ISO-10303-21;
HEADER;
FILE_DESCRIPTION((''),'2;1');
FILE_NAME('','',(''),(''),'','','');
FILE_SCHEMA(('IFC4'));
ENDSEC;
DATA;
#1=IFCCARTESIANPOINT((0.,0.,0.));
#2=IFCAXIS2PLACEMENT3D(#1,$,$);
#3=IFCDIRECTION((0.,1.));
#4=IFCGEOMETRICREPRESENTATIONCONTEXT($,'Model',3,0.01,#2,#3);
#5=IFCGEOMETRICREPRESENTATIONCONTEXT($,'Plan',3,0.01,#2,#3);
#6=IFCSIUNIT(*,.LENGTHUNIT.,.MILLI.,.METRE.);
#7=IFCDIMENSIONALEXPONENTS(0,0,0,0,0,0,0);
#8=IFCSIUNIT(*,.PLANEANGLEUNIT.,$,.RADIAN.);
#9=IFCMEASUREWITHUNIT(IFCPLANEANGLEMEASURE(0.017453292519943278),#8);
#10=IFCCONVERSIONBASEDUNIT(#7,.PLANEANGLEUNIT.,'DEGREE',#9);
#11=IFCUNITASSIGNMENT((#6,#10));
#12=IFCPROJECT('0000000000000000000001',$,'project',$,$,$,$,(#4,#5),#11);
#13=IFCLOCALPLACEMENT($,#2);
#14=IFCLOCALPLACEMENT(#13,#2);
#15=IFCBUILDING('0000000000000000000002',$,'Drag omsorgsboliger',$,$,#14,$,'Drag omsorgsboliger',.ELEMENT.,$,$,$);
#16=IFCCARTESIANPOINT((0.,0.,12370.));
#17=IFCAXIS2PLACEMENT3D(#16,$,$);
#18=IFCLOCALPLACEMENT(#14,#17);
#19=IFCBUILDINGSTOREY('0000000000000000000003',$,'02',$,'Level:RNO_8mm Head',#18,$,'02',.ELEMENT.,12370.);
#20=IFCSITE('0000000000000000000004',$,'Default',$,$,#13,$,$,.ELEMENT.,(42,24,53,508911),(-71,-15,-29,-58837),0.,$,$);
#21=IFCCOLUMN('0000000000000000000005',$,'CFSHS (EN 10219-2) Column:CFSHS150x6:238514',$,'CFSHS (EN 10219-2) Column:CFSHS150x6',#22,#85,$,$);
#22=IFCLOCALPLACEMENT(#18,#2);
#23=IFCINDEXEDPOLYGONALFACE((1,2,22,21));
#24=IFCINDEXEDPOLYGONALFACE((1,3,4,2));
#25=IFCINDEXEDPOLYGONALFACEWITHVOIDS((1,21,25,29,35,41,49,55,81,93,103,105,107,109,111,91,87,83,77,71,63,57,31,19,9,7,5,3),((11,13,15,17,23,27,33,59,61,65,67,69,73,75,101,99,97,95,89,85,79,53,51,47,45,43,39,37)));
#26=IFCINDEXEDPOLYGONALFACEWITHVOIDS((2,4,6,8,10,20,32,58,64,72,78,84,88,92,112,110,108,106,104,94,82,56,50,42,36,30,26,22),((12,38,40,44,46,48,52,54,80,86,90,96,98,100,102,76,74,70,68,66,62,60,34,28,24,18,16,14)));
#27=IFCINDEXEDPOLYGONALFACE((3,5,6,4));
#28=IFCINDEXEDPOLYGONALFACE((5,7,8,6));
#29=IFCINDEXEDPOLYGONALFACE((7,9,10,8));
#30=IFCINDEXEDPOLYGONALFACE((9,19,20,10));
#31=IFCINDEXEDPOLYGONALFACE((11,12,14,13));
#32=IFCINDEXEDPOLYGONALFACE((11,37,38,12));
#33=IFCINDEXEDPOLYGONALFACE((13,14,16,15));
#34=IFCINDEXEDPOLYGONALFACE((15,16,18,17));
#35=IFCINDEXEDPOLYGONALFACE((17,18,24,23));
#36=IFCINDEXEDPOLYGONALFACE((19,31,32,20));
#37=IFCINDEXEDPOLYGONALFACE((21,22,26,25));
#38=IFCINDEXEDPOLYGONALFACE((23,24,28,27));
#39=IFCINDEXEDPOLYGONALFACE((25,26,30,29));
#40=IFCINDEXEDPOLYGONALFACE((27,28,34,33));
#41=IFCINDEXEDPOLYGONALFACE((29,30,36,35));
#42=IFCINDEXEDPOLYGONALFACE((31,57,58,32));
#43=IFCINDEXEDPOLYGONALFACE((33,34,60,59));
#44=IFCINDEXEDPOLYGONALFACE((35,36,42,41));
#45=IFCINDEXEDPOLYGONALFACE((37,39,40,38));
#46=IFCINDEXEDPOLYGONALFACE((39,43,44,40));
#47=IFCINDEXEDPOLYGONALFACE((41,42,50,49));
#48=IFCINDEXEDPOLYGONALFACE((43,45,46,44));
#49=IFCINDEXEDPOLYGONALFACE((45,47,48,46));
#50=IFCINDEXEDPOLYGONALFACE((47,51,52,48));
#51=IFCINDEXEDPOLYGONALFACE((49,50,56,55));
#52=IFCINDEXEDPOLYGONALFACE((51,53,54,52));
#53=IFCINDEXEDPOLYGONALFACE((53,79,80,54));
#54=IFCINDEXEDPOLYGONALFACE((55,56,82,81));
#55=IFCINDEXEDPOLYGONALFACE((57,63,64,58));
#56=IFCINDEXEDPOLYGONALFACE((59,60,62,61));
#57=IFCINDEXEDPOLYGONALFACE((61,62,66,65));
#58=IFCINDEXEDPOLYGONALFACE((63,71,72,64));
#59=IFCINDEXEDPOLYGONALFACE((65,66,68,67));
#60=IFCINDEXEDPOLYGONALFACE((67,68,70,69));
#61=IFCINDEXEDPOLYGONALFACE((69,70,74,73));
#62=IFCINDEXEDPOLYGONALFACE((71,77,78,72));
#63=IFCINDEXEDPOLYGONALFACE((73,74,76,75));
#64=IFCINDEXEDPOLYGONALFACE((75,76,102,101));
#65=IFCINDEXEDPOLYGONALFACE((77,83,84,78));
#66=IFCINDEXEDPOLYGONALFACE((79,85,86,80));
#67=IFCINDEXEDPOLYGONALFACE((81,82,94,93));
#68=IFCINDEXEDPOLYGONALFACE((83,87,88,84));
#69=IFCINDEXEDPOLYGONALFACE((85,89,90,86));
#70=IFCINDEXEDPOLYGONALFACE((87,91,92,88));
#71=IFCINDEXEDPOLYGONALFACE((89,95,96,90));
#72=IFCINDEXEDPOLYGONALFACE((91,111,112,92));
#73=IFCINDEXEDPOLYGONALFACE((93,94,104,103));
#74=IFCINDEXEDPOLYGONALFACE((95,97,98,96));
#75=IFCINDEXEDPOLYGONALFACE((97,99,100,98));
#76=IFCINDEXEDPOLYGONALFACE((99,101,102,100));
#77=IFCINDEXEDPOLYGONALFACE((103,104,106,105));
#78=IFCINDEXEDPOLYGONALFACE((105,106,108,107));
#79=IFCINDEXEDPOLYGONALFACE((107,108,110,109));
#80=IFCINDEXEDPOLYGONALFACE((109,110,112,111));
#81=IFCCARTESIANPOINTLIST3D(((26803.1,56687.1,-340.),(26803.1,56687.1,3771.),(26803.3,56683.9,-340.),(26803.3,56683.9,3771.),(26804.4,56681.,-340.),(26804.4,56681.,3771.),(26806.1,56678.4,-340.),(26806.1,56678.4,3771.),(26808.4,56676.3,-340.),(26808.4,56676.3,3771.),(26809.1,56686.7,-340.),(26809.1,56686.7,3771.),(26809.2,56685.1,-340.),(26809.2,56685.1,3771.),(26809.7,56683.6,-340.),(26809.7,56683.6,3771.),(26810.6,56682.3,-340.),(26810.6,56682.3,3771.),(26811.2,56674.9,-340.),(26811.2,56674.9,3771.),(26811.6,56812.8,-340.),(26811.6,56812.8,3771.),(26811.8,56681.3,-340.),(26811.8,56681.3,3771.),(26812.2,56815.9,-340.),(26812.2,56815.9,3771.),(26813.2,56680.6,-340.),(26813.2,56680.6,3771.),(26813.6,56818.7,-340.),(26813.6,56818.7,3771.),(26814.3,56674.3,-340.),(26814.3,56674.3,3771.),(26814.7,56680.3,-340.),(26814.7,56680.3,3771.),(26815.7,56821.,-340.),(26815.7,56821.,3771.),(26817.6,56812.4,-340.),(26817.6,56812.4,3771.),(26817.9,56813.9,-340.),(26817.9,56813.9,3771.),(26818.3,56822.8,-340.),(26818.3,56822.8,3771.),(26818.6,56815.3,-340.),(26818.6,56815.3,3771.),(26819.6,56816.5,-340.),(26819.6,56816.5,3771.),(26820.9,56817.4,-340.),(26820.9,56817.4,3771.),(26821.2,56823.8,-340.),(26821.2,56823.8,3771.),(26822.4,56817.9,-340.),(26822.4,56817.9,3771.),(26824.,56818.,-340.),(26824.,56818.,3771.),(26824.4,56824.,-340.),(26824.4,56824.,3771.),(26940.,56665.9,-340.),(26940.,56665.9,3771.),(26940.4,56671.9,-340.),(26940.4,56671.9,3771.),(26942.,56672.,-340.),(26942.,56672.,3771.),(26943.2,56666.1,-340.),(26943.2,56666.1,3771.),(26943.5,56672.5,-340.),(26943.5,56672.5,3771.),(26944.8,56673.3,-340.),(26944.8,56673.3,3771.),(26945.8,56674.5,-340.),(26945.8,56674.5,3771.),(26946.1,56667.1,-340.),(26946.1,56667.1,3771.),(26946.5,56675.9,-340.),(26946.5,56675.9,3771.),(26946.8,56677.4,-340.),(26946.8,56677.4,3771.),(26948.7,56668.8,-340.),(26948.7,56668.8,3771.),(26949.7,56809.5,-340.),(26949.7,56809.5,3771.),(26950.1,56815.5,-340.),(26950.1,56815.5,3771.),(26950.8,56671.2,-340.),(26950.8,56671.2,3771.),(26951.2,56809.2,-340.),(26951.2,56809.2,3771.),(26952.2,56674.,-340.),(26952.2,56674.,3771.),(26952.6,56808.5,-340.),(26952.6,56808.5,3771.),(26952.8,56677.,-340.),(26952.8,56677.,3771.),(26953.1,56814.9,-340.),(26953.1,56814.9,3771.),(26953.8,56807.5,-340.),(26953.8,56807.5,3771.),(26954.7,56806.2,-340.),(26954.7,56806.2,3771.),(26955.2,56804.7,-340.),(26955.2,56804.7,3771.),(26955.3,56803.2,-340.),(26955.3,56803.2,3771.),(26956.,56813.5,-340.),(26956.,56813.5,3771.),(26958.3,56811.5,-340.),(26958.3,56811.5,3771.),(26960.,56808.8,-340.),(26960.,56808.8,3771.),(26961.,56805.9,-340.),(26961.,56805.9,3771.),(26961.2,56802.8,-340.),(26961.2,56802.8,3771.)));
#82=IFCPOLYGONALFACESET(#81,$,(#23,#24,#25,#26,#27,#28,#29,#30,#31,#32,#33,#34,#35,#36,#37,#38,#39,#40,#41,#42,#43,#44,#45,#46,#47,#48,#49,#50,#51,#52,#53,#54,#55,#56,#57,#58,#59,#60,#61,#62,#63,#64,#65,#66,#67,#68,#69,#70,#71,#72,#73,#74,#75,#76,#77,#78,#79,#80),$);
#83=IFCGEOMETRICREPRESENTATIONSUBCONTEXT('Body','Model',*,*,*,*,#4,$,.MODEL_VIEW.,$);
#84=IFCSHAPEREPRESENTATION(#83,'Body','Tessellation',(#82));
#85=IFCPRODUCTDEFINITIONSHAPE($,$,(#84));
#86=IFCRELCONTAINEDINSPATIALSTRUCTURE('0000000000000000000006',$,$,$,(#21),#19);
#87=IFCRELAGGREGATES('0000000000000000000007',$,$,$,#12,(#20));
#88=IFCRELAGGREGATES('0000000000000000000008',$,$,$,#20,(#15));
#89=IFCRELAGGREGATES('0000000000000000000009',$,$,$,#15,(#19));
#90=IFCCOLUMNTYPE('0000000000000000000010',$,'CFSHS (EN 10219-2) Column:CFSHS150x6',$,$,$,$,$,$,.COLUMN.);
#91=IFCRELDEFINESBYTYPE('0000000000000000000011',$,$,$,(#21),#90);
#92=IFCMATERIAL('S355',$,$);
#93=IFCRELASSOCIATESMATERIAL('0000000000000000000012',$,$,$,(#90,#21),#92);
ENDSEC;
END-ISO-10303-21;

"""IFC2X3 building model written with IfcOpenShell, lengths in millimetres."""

from ifc_helpers import new_model, entity, si_unit, converted_unit, direction, frame, frame_2d, origin, place, context, subcontext, project, spatial, polyline, circle_curve, parameter, trimmed, segment, composite_curve, outline, extrude, source, transform, mapped, material, type_object, type_shapes, element, save


model = new_model("IFC2X3")

# Units and contexts
model_context = context("Model", 3, precision=0.01, world=origin(), true_north=direction((0.0, 1.0)))
plan_context = context("Plan", 3, precision=0.01, world=origin(), true_north=direction((0.0, 1.0)))
body_context = subcontext(model_context, "Body", "Model", "MODEL_VIEW")
ifc_project = project(units=[si_unit("LENGTHUNIT", "METRE", prefix="MILLI"), converted_unit("PLANEANGLEUNIT", "DEGREE", entity("IfcPlaneAngleMeasure", 0.017453292519943278), si_unit("PLANEANGLEUNIT", "RADIAN"), dimensions=[0, 0, 0, 0, 0, 0, 0])], contexts=[model_context, plan_context])

# Site, building, storey
site_placement = place(None, origin())
site = spatial("IfcSite", under=ifc_project, at=site_placement, Name="Default", CompositionType="ELEMENT", RefLatitude=(42, 24, 53, 508911), RefLongitude=(-71, -15, -29, -58837), RefElevation=0.0)
building_placement = place(site_placement, origin())
building = spatial("IfcBuilding", under=site, at=building_placement, Name="Drag omsorgsboliger", LongName="Drag omsorgsboliger", CompositionType="ELEMENT")
storey_placement = place(building_placement, frame((0.0, 0.0, 12370.0)))
storey = spatial("IfcBuildingStorey", under=building, at=storey_placement, Name="02", ObjectType="Level:RNO_8mm Head", LongName="02", CompositionType="ELEMENT", Elevation=12370.0)

# Column
ifc_material = material(Name="S355")
column_type_1 = type_object("IfcColumnType", Name="CFSHS (EN 10219-2) Column:CFSHS150x6", PredefinedType="COLUMN", material=ifc_material)
shared_shape_1 = source(origin(), body_context, "Body", "SweptSolid", [
    extrude(outline(composite_curve([segment(polyline([(-63.0, -75.0), (63.0, -75.0)]), True, "CONTINUOUS"), segment(trimmed(circle_curve(frame_2d((63.0, -63.0), x_axis=(-1.0, 0.0)), 12.0), [parameter(90.0)], [parameter(180.0)], True, "PARAMETER"), True, "CONTINUOUS"), segment(polyline([(75.0, -63.0), (75.0, 63.0)]), True, "CONTINUOUS"), segment(trimmed(circle_curve(frame_2d((63.0, 63.0), x_axis=(-1.0, 0.0)), 12.0), [parameter(180.0)], [parameter(270.0)], True, "PARAMETER"), True, "CONTINUOUS"), segment(polyline([(63.0, 75.0), (-63.0, 75.0)]), True, "CONTINUOUS"), segment(trimmed(circle_curve(frame_2d((-63.0, 63.0), x_axis=(-1.0, 0.0)), 12.0), [parameter(270.0)], [parameter(360.0)], True, "PARAMETER"), True, "CONTINUOUS"), segment(polyline([(-75.0, 63.0), (-75.0, -63.0)]), True, "CONTINUOUS"), segment(trimmed(circle_curve(frame_2d((-63.0, -63.0), x_axis=(-1.0, 0.0)), 12.0), [parameter(360.0)], [parameter(90.0)], True, "PARAMETER"), True, "CONTINUOUS")], self_intersect=False), holes=[composite_curve([segment(trimmed(circle_curve(frame_2d((-63.0, -63.0), x_axis=(-1.0, 0.0)), 6.0), [parameter(360.0)], [parameter(90.0)], True, "PARAMETER"), False, "CONTINUOUS"), segment(polyline([(-69.0, -63.0), (-69.0, 63.0)]), True, "CONTINUOUS"), segment(trimmed(circle_curve(frame_2d((-63.0, 63.0), x_axis=(-1.0, 0.0)), 6.0), [parameter(270.0)], [parameter(360.0)], True, "PARAMETER"), False, "CONTINUOUS"), segment(polyline([(-63.0, 69.0), (63.0, 69.0)]), True, "CONTINUOUS"), segment(trimmed(circle_curve(frame_2d((63.0, 63.0), x_axis=(-1.0, 0.0)), 6.0), [parameter(180.0)], [parameter(270.0)], True, "PARAMETER"), False, "CONTINUOUS"), segment(polyline([(69.0, 63.0), (69.0, -63.0)]), True, "CONTINUOUS"), segment(trimmed(circle_curve(frame_2d((63.0, -63.0), x_axis=(-1.0, 0.0)), 6.0), [parameter(90.0)], [parameter(180.0)], True, "PARAMETER"), False, "CONTINUOUS"), segment(polyline([(63.0, -69.0), (-63.0, -69.0)]), True, "CONTINUOUS")], self_intersect=False)]), frame((26882.2, 56744.9, 12030.0), z_axis=(0.0, 0.0, 1.0), x_axis=(-0.997758, 0.066923, 0.0)), (0.0, 0.0, 1.0), 4111.0),
])
type_shapes(column_type_1, [shared_shape_1])
column_1_placement = place(storey_placement, frame((0.0, 0.0, -12370.0)))
element("IfcColumn", 1, at=column_1_placement, inside=storey, type_object=column_type_1, material=ifc_material, Name="CFSHS (EN 10219-2) Column:CFSHS150x6:238514", ObjectType="CFSHS (EN 10219-2) Column:CFSHS150x6", context=body_context, shape_type="MappedRepresentation", body=[
    mapped(shared_shape_1, transform((0.0, 0.0, 0.0), scale=1.0)),
])

save(model, "model.ifc")
